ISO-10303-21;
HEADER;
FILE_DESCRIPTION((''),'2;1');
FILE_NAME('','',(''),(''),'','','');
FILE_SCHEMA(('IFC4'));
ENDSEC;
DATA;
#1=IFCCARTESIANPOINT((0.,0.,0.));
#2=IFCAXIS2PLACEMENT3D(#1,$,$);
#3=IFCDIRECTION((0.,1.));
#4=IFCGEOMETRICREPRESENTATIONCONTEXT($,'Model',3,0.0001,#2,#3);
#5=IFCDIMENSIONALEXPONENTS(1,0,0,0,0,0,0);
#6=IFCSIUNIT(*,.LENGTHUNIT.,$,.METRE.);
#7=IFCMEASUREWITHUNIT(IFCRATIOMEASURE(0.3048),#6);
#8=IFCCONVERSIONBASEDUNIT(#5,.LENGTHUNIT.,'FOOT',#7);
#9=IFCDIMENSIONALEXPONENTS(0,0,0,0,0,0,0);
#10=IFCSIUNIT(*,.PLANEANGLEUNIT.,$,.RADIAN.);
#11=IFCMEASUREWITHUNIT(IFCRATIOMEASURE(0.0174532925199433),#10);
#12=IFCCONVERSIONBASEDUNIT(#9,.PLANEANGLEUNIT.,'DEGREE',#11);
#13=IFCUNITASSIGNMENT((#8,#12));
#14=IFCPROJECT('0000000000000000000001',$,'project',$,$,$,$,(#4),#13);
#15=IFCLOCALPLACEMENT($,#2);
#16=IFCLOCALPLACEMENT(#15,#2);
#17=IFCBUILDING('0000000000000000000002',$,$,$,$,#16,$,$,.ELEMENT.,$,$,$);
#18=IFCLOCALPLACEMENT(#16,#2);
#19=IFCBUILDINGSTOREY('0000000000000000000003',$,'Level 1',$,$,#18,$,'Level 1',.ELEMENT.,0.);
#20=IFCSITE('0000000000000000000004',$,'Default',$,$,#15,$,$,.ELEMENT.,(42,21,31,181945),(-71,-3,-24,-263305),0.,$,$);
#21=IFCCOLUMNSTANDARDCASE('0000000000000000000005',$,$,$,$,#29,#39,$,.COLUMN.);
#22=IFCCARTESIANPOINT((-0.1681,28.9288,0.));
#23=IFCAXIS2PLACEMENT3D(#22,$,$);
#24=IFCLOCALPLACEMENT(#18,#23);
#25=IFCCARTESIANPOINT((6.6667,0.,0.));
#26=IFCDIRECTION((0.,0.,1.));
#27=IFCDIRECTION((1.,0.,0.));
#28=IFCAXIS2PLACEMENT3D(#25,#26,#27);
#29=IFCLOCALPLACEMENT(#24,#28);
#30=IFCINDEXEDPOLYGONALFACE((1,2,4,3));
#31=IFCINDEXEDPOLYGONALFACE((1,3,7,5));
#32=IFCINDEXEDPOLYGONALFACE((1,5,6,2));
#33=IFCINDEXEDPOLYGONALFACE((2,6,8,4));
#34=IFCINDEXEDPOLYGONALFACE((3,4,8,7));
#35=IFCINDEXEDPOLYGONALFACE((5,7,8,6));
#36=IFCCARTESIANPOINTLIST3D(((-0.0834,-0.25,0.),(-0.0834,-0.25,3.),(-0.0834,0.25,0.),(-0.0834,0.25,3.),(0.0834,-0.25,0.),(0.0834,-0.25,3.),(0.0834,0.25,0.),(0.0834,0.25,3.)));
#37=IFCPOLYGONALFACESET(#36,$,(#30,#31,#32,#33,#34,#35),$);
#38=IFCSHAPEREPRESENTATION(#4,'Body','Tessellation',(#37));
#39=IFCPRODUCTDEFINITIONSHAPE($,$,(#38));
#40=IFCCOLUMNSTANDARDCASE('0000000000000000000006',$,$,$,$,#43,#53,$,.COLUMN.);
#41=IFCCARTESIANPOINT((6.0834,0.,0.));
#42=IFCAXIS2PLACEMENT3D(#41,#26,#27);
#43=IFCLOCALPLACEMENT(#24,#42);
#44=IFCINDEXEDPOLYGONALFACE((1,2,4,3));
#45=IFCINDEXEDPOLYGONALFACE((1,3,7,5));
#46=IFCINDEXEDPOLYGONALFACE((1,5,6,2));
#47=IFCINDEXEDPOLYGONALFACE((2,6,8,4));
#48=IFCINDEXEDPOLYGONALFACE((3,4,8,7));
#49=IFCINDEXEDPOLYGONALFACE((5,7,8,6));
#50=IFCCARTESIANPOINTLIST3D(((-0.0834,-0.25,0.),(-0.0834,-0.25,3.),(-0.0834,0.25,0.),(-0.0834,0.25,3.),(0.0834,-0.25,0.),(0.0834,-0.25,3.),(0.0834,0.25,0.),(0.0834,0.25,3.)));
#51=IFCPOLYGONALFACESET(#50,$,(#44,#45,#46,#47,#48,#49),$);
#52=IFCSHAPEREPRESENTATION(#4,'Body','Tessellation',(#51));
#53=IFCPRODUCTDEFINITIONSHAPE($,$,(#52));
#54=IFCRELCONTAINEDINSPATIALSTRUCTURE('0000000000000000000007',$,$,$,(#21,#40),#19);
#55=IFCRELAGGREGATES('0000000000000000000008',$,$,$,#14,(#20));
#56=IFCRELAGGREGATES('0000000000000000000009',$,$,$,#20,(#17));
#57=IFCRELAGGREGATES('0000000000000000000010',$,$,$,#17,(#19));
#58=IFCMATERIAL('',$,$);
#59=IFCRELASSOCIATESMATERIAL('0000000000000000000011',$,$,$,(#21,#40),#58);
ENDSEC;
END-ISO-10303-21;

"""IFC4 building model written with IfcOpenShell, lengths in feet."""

from ifc_helpers import new_model, entity, si_unit, converted_unit, direction, frame, origin, place, context, project, spatial, rectangle, extrude, material, element, save


model = new_model("IFC4")

# Units and contexts
model_context = context("Model", 3, precision=0.0001, world=origin(), true_north=direction((0.0, 1.0)))
ifc_project = project(units=[converted_unit("LENGTHUNIT", "FOOT", entity("IfcRatioMeasure", 0.3048), si_unit("LENGTHUNIT", "METRE"), dimensions=[1, 0, 0, 0, 0, 0, 0]), converted_unit("PLANEANGLEUNIT", "DEGREE", entity("IfcRatioMeasure", 0.0174532925199433), si_unit("PLANEANGLEUNIT", "RADIAN"), dimensions=[0, 0, 0, 0, 0, 0, 0])], contexts=[model_context])

# Site, building, storey
site_placement = place(None, origin())
site = spatial("IfcSite", under=ifc_project, at=site_placement, Name="Default", CompositionType="ELEMENT", RefLatitude=(42, 21, 31, 181945), RefLongitude=(-71, -3, -24, -263305), RefElevation=0.0)
building_placement = place(site_placement, origin())
building = spatial("IfcBuilding", under=site, at=building_placement, CompositionType="ELEMENT")
storey_placement = place(building_placement, origin())
storey = spatial("IfcBuildingStorey", under=building, at=storey_placement, Name="Level 1", LongName="Level 1", CompositionType="ELEMENT", Elevation=0.0)

# Columns
ifc_material = material(Name="")
placement = place(storey_placement, frame((-0.1681, 28.9288, 0.0)))
for number, where, z_axis, x_axis in (
    (1, (6.6667, 0.0, 0.0), (0.0, 0.0, 1.0), (1.0, 0.0, 0.0)),
    (2, (6.0834, 0.0, 0.0), (0.0, 0.0, 1.0), (1.0, 0.0, 0.0)),
):
    element("IfcColumnStandardCase", number, at=place(placement, frame(where, z_axis=z_axis, x_axis=x_axis)), inside=storey, material=ifc_material, PredefinedType="COLUMN", context=model_context, shape_type="SweptSolid", body=[
        extrude(rectangle(XDim=0.1667, YDim=0.5), origin(), (0.0, 0.0, 1.0), 3.0),
    ])

save(model, "model.ifc")
